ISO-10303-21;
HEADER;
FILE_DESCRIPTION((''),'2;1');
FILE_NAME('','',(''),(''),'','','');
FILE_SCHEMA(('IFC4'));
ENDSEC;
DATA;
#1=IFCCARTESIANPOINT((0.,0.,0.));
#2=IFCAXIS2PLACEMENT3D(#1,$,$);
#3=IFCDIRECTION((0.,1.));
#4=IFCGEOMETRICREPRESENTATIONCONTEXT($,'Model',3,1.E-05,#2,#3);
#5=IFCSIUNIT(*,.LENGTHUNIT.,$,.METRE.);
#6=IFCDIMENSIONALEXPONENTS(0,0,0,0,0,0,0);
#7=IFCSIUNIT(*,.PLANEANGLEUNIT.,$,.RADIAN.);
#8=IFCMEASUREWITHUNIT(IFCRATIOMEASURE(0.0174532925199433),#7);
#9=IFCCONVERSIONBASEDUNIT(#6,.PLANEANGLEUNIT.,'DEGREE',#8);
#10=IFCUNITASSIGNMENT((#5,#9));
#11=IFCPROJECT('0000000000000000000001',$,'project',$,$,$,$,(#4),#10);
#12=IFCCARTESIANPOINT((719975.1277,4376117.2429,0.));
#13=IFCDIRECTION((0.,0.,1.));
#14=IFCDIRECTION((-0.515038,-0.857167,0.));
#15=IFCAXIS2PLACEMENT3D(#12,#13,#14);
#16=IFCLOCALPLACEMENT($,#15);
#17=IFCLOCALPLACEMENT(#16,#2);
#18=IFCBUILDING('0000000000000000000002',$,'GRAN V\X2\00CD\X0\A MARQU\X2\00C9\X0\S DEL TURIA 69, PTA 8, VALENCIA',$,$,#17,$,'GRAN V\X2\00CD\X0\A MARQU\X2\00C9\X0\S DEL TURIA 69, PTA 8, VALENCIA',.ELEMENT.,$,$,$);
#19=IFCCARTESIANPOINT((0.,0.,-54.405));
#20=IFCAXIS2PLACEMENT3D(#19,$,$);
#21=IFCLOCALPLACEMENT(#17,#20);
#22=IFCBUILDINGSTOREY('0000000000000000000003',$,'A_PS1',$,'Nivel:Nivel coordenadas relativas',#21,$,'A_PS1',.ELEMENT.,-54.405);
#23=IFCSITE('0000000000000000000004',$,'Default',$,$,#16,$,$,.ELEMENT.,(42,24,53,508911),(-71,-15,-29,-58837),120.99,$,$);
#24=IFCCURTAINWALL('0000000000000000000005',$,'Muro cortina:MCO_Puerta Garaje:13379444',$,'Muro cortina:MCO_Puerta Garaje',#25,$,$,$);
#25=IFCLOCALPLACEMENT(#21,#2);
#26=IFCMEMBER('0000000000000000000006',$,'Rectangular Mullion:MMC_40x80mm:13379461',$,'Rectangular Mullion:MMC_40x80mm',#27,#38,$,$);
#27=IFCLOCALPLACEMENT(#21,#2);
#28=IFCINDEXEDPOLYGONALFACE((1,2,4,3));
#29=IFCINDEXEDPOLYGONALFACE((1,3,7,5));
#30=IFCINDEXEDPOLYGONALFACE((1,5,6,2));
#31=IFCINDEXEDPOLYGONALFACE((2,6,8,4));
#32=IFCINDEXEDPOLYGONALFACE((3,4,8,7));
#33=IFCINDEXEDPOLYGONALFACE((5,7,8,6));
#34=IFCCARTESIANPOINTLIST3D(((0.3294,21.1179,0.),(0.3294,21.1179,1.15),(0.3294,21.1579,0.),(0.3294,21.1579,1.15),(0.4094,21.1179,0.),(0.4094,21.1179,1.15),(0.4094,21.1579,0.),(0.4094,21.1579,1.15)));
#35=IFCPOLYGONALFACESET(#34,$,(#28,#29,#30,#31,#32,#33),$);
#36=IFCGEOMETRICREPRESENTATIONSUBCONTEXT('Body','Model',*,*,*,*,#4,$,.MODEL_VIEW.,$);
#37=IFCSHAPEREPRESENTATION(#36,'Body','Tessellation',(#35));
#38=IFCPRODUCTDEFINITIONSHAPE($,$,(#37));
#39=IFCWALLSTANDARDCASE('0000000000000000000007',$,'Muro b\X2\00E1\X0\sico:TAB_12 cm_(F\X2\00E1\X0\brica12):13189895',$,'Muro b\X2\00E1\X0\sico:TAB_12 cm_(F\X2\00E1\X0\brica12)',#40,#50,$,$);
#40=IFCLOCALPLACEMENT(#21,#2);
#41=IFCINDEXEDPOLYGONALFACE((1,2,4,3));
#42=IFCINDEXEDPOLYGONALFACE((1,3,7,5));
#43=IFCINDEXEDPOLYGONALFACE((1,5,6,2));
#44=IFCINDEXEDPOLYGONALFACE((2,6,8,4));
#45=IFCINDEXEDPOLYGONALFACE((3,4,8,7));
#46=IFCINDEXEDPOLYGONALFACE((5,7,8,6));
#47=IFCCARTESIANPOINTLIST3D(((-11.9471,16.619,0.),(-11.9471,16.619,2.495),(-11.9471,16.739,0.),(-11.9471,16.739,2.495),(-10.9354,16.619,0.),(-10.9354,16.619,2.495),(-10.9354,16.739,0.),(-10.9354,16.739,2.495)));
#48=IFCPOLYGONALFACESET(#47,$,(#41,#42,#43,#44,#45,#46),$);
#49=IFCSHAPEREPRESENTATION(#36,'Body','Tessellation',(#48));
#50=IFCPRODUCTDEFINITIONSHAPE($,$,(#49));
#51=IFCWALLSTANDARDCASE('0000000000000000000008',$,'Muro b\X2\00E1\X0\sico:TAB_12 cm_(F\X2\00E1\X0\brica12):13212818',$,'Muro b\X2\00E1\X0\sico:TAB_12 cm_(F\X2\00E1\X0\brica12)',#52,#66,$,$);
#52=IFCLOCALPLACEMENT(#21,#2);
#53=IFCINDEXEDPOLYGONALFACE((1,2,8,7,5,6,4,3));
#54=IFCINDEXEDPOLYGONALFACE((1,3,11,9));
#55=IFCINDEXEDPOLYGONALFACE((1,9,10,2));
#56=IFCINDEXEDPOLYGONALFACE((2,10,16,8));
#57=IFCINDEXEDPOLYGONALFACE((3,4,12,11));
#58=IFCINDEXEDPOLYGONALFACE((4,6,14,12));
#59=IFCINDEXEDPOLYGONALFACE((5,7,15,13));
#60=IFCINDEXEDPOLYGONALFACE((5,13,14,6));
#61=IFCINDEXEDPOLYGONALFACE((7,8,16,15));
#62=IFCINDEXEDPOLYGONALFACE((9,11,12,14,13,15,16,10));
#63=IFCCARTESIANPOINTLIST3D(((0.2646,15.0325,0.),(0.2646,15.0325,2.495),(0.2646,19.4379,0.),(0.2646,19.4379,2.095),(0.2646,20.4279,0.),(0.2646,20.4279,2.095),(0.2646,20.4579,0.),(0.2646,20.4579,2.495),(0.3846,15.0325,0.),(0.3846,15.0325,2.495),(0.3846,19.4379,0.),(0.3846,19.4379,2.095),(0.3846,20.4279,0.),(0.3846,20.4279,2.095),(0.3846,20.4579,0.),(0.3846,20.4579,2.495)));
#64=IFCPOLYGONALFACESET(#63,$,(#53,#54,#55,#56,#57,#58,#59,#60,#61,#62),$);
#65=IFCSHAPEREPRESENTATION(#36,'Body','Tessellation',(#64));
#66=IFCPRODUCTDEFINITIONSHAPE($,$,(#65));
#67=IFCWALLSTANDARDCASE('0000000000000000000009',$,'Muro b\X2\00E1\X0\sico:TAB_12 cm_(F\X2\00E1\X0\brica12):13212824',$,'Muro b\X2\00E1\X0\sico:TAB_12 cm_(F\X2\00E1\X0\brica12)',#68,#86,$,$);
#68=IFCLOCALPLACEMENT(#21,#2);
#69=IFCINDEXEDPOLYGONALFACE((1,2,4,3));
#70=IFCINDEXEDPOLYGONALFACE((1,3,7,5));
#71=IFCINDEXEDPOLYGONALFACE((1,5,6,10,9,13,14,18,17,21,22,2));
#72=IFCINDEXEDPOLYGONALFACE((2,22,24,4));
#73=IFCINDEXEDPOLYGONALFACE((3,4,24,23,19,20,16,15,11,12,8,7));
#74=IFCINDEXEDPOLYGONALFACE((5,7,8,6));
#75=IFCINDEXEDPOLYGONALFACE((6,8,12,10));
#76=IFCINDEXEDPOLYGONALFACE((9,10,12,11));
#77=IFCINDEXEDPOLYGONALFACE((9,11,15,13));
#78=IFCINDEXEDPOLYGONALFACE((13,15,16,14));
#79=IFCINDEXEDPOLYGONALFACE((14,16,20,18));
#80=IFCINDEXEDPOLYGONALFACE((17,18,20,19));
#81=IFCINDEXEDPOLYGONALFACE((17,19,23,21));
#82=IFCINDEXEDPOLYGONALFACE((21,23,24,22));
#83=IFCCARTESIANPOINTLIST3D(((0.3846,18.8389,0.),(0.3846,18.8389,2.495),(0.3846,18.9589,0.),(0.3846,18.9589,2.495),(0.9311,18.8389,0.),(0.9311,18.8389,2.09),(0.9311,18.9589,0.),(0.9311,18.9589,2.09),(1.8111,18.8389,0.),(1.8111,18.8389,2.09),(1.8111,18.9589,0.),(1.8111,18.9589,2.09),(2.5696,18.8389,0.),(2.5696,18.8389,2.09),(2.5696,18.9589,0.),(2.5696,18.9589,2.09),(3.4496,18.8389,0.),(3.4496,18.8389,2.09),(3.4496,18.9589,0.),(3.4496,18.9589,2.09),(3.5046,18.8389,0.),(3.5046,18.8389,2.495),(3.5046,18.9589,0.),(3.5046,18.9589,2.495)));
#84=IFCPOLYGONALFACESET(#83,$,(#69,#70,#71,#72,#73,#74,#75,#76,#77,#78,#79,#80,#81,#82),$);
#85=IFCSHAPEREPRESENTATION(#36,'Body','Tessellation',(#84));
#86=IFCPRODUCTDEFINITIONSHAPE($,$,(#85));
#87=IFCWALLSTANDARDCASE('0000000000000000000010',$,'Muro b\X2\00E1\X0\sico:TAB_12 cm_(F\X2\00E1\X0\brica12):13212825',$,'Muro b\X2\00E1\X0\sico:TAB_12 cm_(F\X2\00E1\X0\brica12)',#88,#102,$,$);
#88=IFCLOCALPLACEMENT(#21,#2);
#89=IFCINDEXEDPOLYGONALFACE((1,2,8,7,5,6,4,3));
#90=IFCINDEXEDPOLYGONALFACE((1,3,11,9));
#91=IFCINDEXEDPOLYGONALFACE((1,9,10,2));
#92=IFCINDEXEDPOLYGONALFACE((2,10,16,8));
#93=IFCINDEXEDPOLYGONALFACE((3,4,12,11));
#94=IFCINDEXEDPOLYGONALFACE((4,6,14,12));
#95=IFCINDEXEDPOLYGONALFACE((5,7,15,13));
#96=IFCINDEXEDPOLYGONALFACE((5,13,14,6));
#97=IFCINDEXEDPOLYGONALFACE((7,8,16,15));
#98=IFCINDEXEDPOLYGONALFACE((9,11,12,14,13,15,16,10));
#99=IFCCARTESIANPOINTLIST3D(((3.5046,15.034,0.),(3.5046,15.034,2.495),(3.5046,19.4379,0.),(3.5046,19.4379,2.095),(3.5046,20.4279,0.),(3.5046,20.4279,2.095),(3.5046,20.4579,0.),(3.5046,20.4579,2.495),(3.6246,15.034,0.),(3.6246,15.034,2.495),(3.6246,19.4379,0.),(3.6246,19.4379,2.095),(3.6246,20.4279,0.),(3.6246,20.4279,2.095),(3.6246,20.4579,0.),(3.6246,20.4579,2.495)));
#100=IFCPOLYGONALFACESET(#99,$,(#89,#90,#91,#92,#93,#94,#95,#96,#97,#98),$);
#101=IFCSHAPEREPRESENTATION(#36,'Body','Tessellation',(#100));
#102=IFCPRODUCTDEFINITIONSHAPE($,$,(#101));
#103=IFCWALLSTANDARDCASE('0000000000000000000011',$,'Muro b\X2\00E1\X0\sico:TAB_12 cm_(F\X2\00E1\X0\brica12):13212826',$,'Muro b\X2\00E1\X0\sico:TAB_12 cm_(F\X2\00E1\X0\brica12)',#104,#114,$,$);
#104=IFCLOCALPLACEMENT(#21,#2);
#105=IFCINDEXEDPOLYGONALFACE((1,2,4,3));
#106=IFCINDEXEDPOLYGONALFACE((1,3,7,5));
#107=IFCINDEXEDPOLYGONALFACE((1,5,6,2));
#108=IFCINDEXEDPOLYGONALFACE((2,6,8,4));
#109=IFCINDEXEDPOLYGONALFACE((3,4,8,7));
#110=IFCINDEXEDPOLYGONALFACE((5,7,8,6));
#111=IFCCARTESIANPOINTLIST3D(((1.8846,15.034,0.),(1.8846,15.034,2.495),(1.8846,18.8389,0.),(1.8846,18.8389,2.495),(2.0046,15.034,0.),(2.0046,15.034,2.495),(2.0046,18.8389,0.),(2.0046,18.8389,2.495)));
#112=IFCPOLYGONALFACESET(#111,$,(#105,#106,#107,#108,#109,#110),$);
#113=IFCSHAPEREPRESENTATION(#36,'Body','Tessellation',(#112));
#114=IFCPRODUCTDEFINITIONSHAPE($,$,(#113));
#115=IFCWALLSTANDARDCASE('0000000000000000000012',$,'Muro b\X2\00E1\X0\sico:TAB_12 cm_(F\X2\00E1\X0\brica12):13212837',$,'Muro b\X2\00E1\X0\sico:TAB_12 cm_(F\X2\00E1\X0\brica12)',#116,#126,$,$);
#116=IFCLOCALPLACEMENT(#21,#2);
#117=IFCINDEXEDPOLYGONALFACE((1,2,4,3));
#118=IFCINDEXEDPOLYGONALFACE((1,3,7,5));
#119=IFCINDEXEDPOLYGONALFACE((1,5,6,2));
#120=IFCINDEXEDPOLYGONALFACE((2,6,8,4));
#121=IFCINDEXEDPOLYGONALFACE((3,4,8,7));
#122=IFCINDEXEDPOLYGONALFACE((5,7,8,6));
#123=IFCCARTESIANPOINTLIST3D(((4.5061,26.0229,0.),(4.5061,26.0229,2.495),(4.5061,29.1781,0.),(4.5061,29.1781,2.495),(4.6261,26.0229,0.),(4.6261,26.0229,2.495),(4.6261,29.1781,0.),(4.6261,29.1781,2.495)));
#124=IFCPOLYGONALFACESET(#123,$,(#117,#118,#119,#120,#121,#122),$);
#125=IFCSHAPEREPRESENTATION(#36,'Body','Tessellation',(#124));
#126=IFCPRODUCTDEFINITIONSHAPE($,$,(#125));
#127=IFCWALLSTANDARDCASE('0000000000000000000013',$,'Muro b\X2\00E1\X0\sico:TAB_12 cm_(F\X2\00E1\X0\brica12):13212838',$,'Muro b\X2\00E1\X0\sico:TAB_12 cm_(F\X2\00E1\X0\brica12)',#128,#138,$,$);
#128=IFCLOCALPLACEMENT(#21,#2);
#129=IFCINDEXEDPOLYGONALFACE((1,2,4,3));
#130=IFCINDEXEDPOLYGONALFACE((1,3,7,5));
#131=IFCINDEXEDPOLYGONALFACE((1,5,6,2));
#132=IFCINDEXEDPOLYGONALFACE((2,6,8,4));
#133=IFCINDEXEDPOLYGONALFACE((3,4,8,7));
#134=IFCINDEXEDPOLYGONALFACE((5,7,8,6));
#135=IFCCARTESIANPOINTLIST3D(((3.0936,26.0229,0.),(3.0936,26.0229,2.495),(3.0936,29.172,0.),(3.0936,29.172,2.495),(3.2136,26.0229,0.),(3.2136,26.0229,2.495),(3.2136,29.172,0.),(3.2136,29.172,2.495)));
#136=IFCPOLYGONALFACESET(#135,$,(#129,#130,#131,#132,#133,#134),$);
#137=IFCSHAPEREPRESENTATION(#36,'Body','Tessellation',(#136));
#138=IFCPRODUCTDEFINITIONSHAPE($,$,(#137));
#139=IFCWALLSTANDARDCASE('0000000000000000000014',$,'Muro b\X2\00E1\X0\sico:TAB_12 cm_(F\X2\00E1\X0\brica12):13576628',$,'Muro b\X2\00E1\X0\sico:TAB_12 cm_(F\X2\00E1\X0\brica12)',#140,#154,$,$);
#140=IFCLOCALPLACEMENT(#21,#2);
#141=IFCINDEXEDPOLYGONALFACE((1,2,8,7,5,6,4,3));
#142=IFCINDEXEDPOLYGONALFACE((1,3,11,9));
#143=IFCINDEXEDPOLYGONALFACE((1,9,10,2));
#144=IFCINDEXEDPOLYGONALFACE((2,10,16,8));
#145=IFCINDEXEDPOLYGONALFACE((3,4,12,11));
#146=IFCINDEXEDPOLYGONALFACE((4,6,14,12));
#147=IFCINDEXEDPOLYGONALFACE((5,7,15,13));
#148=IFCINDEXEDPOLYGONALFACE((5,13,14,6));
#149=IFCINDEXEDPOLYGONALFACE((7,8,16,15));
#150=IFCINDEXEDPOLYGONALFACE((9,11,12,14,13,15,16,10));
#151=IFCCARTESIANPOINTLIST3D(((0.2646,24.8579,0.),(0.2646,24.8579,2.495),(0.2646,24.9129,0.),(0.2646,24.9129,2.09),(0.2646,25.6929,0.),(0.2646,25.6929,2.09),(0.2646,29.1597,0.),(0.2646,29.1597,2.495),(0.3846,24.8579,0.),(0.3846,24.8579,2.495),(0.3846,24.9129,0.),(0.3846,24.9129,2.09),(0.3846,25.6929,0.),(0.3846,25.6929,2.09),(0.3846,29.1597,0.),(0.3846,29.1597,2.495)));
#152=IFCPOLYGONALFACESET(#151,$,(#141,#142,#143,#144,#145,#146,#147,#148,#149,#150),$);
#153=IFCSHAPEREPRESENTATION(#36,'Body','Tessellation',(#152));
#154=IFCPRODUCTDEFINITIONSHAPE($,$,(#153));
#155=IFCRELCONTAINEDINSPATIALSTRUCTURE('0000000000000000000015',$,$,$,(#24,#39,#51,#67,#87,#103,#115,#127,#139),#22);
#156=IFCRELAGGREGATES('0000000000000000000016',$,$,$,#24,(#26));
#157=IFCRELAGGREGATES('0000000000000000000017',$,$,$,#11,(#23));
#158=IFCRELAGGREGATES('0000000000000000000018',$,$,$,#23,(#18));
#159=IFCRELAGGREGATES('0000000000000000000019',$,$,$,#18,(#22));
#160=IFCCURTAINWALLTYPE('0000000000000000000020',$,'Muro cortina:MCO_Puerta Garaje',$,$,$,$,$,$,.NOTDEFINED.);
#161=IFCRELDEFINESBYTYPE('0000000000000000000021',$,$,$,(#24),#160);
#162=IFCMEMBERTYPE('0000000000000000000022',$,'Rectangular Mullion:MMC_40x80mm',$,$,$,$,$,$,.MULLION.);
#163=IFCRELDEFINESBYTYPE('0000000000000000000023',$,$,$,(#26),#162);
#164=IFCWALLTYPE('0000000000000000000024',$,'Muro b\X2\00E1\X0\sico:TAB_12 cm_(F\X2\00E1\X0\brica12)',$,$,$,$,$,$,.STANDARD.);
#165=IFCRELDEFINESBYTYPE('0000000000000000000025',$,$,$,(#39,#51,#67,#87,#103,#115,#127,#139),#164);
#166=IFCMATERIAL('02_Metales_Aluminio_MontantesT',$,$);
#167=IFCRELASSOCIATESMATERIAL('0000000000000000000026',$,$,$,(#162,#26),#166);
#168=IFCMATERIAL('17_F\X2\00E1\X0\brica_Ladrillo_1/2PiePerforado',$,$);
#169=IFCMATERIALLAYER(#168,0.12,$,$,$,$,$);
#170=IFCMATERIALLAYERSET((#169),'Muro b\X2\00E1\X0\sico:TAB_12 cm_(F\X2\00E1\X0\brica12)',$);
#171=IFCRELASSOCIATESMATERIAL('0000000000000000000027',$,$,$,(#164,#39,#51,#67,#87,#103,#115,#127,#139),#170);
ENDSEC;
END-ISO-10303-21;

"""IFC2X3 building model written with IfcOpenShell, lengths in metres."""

from ifc_helpers import new_model, entity, si_unit, converted_unit, direction, frame, frame_2d, origin, origin_2d_with_axis, place, context, subcontext, project, spatial, rectangle, extrude, source, transform, mapped, material, layer, layer_set, layer_usage, type_object, type_shapes, element, aggregate, save


model = new_model("IFC2X3")

# Units and contexts
model_context = context("Model", 3, precision=1e-05, world=origin(), true_north=direction((0.0, 1.0)))
body_context = subcontext(model_context, "Body", "Model", "MODEL_VIEW")
ifc_project = project(units=[si_unit("LENGTHUNIT", "METRE"), converted_unit("PLANEANGLEUNIT", "DEGREE", entity("IfcRatioMeasure", 0.0174532925199433), si_unit("PLANEANGLEUNIT", "RADIAN"), dimensions=[0, 0, 0, 0, 0, 0, 0])], contexts=[model_context])

# Site, building, storey
site_placement = place(None, frame((719975.1277, 4376117.2429, 0.0), z_axis=(0.0, 0.0, 1.0), x_axis=(-0.515038, -0.857167, 0.0)))
site = spatial("IfcSite", under=ifc_project, at=site_placement, Name="Default", CompositionType="ELEMENT", RefLatitude=(42, 24, 53, 508911), RefLongitude=(-71, -15, -29, -58837), RefElevation=120.99)
building_placement = place(site_placement, origin())
building = spatial("IfcBuilding", under=site, at=building_placement, Name="GRAN VÍA MARQUÉS DEL TURIA 69, PTA 8, VALENCIA", LongName="GRAN VÍA MARQUÉS DEL TURIA 69, PTA 8, VALENCIA", CompositionType="ELEMENT")
storey_placement = place(building_placement, frame((0.0, 0.0, -54.405)))
storey = spatial("IfcBuildingStorey", under=building, at=storey_placement, Name="A_PS1", ObjectType="Nivel:Nivel coordenadas relativas", LongName="A_PS1", CompositionType="ELEMENT", Elevation=-54.405)

# Curtain wall, member
curtain_wall_type = type_object("IfcCurtainWallType", Name="Muro cortina:MCO_Puerta Garaje", PredefinedType="NOTDEFINED")
curtain_wall_placement = place(storey_placement, frame((0.0, 0.0, 54.405)))
curtain_wall = element("IfcCurtainWall", 1, at=curtain_wall_placement, inside=storey, type_object=curtain_wall_type, Name="Muro cortina:MCO_Puerta Garaje:13379444", ObjectType="Muro cortina:MCO_Puerta Garaje")
ifc_material_1 = material(Name="02_Metales_Aluminio_MontantesT")
member_type = type_object("IfcMemberType", Name="Rectangular Mullion:MMC_40x80mm", PredefinedType="MULLION", material=ifc_material_1)
shared_shape = source(origin(), body_context, "Body", "SweptSolid", [
    extrude(rectangle(XDim=0.08, YDim=0.04, at=origin_2d_with_axis()), frame((-0.02, 0.0, -1.15), z_axis=(0.0, 0.0, 1.0), x_axis=(0.0, -1.0, 0.0)), (0.0, 0.0, 1.0), 1.15),
])
type_shapes(member_type, [shared_shape])
member_placement = place(storey_placement, frame((0.3694, 21.1179, 0.0), z_axis=(0.0, 0.0, -1.0), x_axis=(0.0, -1.0, 0.0)))
member = element("IfcMember", 2, at=member_placement, type_object=member_type, material=ifc_material_1, Name="Rectangular Mullion:MMC_40x80mm:13379461", ObjectType="Rectangular Mullion:MMC_40x80mm", context=body_context, shape_type="MappedRepresentation", body=[
    mapped(shared_shape, transform((0.0, 0.0, 0.0), scale=1.0)),
])

# Wall
ifc_material_2 = material(Name="17_Fábrica_Ladrillo_1/2PiePerforado")
ifc_layer_1 = layer(ifc_material_2, 0.12)
ifc_layer_set_1 = layer_set([ifc_layer_1], Name="Muro básico:TAB_12 cm_(Fábrica12)")
ifc_layer_usage_1 = layer_usage(ifc_layer_set_1, "AXIS2", "NEGATIVE", 0.06)
wall_type_1 = type_object("IfcWallType", Name="Muro básico:TAB_12 cm_(Fábrica12)", PredefinedType="STANDARD", material=ifc_layer_set_1)
wall_1_placement = place(storey_placement, frame((-10.9354, 16.679, 0.0), z_axis=(0.0, 0.0, 1.0), x_axis=(-1.0, 0.0, 0.0)))
element("IfcWallStandardCase", 3, at=wall_1_placement, inside=storey, type_object=wall_type_1, material=ifc_layer_usage_1, Name="Muro básico:TAB_12 cm_(Fábrica12):13189895", ObjectType="Muro básico:TAB_12 cm_(Fábrica12)", context=body_context, shape_type="SweptSolid", body=[
    extrude(rectangle(XDim=1.0117, YDim=0.12, at=frame_2d((0.5058, 0.0), x_axis=(-1.0, 0.0))), origin(), (0.0, 0.0, 1.0), 2.495),
])

# Wall, opening
ifc_layer_usage_2 = layer_usage(ifc_layer_set_1, "AXIS2", "NEGATIVE", 0.06)
wall_2_placement = place(storey_placement, frame((0.3246, 20.4579, 0.0), z_axis=(0.0, 0.0, 1.0), x_axis=(0.0, -1.0, 0.0)))
wall_2 = element("IfcWallStandardCase", 4, at=wall_2_placement, inside=storey, type_object=wall_type_1, material=ifc_layer_usage_2, Name="Muro básico:TAB_12 cm_(Fábrica12):13212818", ObjectType="Muro básico:TAB_12 cm_(Fábrica12)", context=body_context, shape_type="SweptSolid", body=[
    extrude(rectangle(XDim=5.4255, YDim=0.12, at=frame_2d((2.7127, 0.0), x_axis=(-1.0, 0.0))), origin(), (0.0, 0.0, 1.0), 2.495),
])
opening_1_placement = place(wall_2_placement, frame((0.03, -0.06, 0.0)))
element("IfcOpeningElement", 5, at=opening_1_placement, cuts=wall_2, ObjectType="Opening", context=body_context, shape_type="SweptSolid", body=[
    extrude(rectangle(XDim=2.095, YDim=0.99, at=frame_2d((1.0475, 0.495), x_axis=(-1.0, 0.0))), frame((0.0, 0.0, 0.0), z_axis=(0.0, 1.0, 0.0), x_axis=(0.0, 0.0, 1.0)), (0.0, 0.0, 1.0), 0.12),
])

# Wall, openings
ifc_layer_usage_3 = layer_usage(ifc_layer_set_1, "AXIS2", "NEGATIVE", 0.06)
wall_3_placement = place(storey_placement, frame((0.3846, 18.8989, 0.0)))
wall_3 = element("IfcWallStandardCase", 6, at=wall_3_placement, inside=storey, type_object=wall_type_1, material=ifc_layer_usage_3, Name="Muro básico:TAB_12 cm_(Fábrica12):13212824", ObjectType="Muro básico:TAB_12 cm_(Fábrica12)", context=body_context, shape_type="SweptSolid", body=[
    extrude(rectangle(XDim=3.12, YDim=0.12, at=frame_2d((1.56, 0.0), x_axis=(-1.0, 0.0))), origin(), (0.0, 0.0, 1.0), 2.495),
])
opening_2_placement = place(wall_3_placement, frame((3.065, 0.06, 0.0)))
element("IfcOpeningElement", 7, at=opening_2_placement, cuts=wall_3, ObjectType="Opening", context=body_context, shape_type="SweptSolid", body=[
    extrude(rectangle(XDim=2.09, YDim=0.88, at=frame_2d((1.045, 0.44), x_axis=(1.0, 0.0))), frame((0.0, 0.0, 0.0), z_axis=(0.0, -1.0, 0.0), x_axis=(0.0, 0.0, 1.0)), (0.0, 0.0, 1.0), 0.12),
])
opening_3_placement = place(wall_3_placement, frame((1.4265, 0.06, 0.0)))
element("IfcOpeningElement", 8, at=opening_3_placement, cuts=wall_3, ObjectType="Opening", context=body_context, shape_type="SweptSolid", body=[
    extrude(rectangle(XDim=2.09, YDim=0.88, at=frame_2d((1.045, 0.44), x_axis=(1.0, 0.0))), frame((0.0, 0.0, 0.0), z_axis=(0.0, -1.0, 0.0), x_axis=(0.0, 0.0, 1.0)), (0.0, 0.0, 1.0), 0.12),
])

# Wall, opening
ifc_layer_usage_4 = layer_usage(ifc_layer_set_1, "AXIS2", "NEGATIVE", 0.06)
wall_4_placement = place(storey_placement, frame((3.5646, 15.034, 0.0), z_axis=(0.0, 0.0, 1.0), x_axis=(0.0, 1.0, 0.0)))
wall_4 = element("IfcWallStandardCase", 9, at=wall_4_placement, inside=storey, type_object=wall_type_1, material=ifc_layer_usage_4, Name="Muro básico:TAB_12 cm_(Fábrica12):13212825", ObjectType="Muro básico:TAB_12 cm_(Fábrica12)", context=body_context, shape_type="SweptSolid", body=[
    extrude(rectangle(XDim=5.4239, YDim=0.12, at=frame_2d((2.7119, 0.0), x_axis=(-1.0, 0.0))), origin(), (0.0, 0.0, 1.0), 2.495),
])
opening_4_placement = place(wall_4_placement, frame((4.4039, -0.06, 0.0)))
element("IfcOpeningElement", 10, at=opening_4_placement, cuts=wall_4, ObjectType="Opening", context=body_context, shape_type="SweptSolid", body=[
    extrude(rectangle(XDim=2.095, YDim=0.99, at=frame_2d((1.0475, 0.495), x_axis=(-1.0, 0.0))), frame((0.0, 0.0, 0.0), z_axis=(0.0, 1.0, 0.0), x_axis=(0.0, 0.0, 1.0)), (0.0, 0.0, 1.0), 0.12),
])

# Walls
ifc_layer_usage_5 = layer_usage(ifc_layer_set_1, "AXIS2", "NEGATIVE", 0.06)
wall_5_placement = place(storey_placement, frame((1.9446, 15.034, 0.0), z_axis=(0.0, 0.0, 1.0), x_axis=(0.0, 1.0, 0.0)))
element("IfcWallStandardCase", 11, at=wall_5_placement, inside=storey, type_object=wall_type_1, material=ifc_layer_usage_5, Name="Muro básico:TAB_12 cm_(Fábrica12):13212826", ObjectType="Muro básico:TAB_12 cm_(Fábrica12)", context=body_context, shape_type="SweptSolid", body=[
    extrude(rectangle(XDim=3.8049, YDim=0.12, at=frame_2d((1.9024, 0.0), x_axis=(-1.0, 0.0))), origin(), (0.0, 0.0, 1.0), 2.495),
])
ifc_layer_usage_6 = layer_usage(ifc_layer_set_1, "AXIS2", "NEGATIVE", 0.06)
wall_6_placement = place(storey_placement, frame((4.5661, 26.0229, 0.0), z_axis=(0.0, 0.0, 1.0), x_axis=(0.0, 1.0, 0.0)))
element("IfcWallStandardCase", 12, at=wall_6_placement, inside=storey, type_object=wall_type_1, material=ifc_layer_usage_6, Name="Muro básico:TAB_12 cm_(Fábrica12):13212837", ObjectType="Muro básico:TAB_12 cm_(Fábrica12)", context=body_context, shape_type="SweptSolid", body=[
    extrude(rectangle(XDim=3.1551, YDim=0.12, at=frame_2d((1.5776, 0.0), x_axis=(-1.0, 0.0))), origin(), (0.0, 0.0, 1.0), 2.495),
])
ifc_layer_usage_7 = layer_usage(ifc_layer_set_1, "AXIS2", "NEGATIVE", 0.06)
wall_7_placement = place(storey_placement, frame((3.1536, 26.0229, 0.0), z_axis=(0.0, 0.0, 1.0), x_axis=(0.0, 1.0, 0.0)))
element("IfcWallStandardCase", 13, at=wall_7_placement, inside=storey, type_object=wall_type_1, material=ifc_layer_usage_7, Name="Muro básico:TAB_12 cm_(Fábrica12):13212838", ObjectType="Muro básico:TAB_12 cm_(Fábrica12)", context=body_context, shape_type="SweptSolid", body=[
    extrude(rectangle(XDim=3.149, YDim=0.12, at=frame_2d((1.5745, 0.0), x_axis=(-1.0, 0.0))), origin(), (0.0, 0.0, 1.0), 2.495),
])

# Wall, opening
ifc_layer_usage_8 = layer_usage(ifc_layer_set_1, "AXIS2", "NEGATIVE", 0.06)
wall_8_placement = place(storey_placement, frame((0.3246, 24.8579, 0.0), z_axis=(0.0, 0.0, 1.0), x_axis=(0.0, 1.0, 0.0)))
wall_8 = element("IfcWallStandardCase", 14, at=wall_8_placement, inside=storey, type_object=wall_type_1, material=ifc_layer_usage_8, Name="Muro básico:TAB_12 cm_(Fábrica12):13576628", ObjectType="Muro básico:TAB_12 cm_(Fábrica12)", context=body_context, shape_type="SweptSolid", body=[
    extrude(rectangle(XDim=4.3018, YDim=0.12, at=frame_2d((2.1509, 0.0), x_axis=(-1.0, 0.0))), origin(), (0.0, 0.0, 1.0), 2.495),
])
opening_5_placement = place(wall_8_placement, frame((0.835, 0.06, 0.0)))
element("IfcOpeningElement", 15, at=opening_5_placement, cuts=wall_8, ObjectType="Opening", context=body_context, shape_type="SweptSolid", body=[
    extrude(rectangle(XDim=2.09, YDim=0.78, at=frame_2d((1.045, 0.39), x_axis=(1.0, 0.0))), frame((0.0, 0.0, 0.0), z_axis=(0.0, -1.0, 0.0), x_axis=(0.0, 0.0, 1.0)), (0.0, 0.0, 1.0), 0.12),
])

aggregate(curtain_wall, [member])

save(model, "model.ifc")
